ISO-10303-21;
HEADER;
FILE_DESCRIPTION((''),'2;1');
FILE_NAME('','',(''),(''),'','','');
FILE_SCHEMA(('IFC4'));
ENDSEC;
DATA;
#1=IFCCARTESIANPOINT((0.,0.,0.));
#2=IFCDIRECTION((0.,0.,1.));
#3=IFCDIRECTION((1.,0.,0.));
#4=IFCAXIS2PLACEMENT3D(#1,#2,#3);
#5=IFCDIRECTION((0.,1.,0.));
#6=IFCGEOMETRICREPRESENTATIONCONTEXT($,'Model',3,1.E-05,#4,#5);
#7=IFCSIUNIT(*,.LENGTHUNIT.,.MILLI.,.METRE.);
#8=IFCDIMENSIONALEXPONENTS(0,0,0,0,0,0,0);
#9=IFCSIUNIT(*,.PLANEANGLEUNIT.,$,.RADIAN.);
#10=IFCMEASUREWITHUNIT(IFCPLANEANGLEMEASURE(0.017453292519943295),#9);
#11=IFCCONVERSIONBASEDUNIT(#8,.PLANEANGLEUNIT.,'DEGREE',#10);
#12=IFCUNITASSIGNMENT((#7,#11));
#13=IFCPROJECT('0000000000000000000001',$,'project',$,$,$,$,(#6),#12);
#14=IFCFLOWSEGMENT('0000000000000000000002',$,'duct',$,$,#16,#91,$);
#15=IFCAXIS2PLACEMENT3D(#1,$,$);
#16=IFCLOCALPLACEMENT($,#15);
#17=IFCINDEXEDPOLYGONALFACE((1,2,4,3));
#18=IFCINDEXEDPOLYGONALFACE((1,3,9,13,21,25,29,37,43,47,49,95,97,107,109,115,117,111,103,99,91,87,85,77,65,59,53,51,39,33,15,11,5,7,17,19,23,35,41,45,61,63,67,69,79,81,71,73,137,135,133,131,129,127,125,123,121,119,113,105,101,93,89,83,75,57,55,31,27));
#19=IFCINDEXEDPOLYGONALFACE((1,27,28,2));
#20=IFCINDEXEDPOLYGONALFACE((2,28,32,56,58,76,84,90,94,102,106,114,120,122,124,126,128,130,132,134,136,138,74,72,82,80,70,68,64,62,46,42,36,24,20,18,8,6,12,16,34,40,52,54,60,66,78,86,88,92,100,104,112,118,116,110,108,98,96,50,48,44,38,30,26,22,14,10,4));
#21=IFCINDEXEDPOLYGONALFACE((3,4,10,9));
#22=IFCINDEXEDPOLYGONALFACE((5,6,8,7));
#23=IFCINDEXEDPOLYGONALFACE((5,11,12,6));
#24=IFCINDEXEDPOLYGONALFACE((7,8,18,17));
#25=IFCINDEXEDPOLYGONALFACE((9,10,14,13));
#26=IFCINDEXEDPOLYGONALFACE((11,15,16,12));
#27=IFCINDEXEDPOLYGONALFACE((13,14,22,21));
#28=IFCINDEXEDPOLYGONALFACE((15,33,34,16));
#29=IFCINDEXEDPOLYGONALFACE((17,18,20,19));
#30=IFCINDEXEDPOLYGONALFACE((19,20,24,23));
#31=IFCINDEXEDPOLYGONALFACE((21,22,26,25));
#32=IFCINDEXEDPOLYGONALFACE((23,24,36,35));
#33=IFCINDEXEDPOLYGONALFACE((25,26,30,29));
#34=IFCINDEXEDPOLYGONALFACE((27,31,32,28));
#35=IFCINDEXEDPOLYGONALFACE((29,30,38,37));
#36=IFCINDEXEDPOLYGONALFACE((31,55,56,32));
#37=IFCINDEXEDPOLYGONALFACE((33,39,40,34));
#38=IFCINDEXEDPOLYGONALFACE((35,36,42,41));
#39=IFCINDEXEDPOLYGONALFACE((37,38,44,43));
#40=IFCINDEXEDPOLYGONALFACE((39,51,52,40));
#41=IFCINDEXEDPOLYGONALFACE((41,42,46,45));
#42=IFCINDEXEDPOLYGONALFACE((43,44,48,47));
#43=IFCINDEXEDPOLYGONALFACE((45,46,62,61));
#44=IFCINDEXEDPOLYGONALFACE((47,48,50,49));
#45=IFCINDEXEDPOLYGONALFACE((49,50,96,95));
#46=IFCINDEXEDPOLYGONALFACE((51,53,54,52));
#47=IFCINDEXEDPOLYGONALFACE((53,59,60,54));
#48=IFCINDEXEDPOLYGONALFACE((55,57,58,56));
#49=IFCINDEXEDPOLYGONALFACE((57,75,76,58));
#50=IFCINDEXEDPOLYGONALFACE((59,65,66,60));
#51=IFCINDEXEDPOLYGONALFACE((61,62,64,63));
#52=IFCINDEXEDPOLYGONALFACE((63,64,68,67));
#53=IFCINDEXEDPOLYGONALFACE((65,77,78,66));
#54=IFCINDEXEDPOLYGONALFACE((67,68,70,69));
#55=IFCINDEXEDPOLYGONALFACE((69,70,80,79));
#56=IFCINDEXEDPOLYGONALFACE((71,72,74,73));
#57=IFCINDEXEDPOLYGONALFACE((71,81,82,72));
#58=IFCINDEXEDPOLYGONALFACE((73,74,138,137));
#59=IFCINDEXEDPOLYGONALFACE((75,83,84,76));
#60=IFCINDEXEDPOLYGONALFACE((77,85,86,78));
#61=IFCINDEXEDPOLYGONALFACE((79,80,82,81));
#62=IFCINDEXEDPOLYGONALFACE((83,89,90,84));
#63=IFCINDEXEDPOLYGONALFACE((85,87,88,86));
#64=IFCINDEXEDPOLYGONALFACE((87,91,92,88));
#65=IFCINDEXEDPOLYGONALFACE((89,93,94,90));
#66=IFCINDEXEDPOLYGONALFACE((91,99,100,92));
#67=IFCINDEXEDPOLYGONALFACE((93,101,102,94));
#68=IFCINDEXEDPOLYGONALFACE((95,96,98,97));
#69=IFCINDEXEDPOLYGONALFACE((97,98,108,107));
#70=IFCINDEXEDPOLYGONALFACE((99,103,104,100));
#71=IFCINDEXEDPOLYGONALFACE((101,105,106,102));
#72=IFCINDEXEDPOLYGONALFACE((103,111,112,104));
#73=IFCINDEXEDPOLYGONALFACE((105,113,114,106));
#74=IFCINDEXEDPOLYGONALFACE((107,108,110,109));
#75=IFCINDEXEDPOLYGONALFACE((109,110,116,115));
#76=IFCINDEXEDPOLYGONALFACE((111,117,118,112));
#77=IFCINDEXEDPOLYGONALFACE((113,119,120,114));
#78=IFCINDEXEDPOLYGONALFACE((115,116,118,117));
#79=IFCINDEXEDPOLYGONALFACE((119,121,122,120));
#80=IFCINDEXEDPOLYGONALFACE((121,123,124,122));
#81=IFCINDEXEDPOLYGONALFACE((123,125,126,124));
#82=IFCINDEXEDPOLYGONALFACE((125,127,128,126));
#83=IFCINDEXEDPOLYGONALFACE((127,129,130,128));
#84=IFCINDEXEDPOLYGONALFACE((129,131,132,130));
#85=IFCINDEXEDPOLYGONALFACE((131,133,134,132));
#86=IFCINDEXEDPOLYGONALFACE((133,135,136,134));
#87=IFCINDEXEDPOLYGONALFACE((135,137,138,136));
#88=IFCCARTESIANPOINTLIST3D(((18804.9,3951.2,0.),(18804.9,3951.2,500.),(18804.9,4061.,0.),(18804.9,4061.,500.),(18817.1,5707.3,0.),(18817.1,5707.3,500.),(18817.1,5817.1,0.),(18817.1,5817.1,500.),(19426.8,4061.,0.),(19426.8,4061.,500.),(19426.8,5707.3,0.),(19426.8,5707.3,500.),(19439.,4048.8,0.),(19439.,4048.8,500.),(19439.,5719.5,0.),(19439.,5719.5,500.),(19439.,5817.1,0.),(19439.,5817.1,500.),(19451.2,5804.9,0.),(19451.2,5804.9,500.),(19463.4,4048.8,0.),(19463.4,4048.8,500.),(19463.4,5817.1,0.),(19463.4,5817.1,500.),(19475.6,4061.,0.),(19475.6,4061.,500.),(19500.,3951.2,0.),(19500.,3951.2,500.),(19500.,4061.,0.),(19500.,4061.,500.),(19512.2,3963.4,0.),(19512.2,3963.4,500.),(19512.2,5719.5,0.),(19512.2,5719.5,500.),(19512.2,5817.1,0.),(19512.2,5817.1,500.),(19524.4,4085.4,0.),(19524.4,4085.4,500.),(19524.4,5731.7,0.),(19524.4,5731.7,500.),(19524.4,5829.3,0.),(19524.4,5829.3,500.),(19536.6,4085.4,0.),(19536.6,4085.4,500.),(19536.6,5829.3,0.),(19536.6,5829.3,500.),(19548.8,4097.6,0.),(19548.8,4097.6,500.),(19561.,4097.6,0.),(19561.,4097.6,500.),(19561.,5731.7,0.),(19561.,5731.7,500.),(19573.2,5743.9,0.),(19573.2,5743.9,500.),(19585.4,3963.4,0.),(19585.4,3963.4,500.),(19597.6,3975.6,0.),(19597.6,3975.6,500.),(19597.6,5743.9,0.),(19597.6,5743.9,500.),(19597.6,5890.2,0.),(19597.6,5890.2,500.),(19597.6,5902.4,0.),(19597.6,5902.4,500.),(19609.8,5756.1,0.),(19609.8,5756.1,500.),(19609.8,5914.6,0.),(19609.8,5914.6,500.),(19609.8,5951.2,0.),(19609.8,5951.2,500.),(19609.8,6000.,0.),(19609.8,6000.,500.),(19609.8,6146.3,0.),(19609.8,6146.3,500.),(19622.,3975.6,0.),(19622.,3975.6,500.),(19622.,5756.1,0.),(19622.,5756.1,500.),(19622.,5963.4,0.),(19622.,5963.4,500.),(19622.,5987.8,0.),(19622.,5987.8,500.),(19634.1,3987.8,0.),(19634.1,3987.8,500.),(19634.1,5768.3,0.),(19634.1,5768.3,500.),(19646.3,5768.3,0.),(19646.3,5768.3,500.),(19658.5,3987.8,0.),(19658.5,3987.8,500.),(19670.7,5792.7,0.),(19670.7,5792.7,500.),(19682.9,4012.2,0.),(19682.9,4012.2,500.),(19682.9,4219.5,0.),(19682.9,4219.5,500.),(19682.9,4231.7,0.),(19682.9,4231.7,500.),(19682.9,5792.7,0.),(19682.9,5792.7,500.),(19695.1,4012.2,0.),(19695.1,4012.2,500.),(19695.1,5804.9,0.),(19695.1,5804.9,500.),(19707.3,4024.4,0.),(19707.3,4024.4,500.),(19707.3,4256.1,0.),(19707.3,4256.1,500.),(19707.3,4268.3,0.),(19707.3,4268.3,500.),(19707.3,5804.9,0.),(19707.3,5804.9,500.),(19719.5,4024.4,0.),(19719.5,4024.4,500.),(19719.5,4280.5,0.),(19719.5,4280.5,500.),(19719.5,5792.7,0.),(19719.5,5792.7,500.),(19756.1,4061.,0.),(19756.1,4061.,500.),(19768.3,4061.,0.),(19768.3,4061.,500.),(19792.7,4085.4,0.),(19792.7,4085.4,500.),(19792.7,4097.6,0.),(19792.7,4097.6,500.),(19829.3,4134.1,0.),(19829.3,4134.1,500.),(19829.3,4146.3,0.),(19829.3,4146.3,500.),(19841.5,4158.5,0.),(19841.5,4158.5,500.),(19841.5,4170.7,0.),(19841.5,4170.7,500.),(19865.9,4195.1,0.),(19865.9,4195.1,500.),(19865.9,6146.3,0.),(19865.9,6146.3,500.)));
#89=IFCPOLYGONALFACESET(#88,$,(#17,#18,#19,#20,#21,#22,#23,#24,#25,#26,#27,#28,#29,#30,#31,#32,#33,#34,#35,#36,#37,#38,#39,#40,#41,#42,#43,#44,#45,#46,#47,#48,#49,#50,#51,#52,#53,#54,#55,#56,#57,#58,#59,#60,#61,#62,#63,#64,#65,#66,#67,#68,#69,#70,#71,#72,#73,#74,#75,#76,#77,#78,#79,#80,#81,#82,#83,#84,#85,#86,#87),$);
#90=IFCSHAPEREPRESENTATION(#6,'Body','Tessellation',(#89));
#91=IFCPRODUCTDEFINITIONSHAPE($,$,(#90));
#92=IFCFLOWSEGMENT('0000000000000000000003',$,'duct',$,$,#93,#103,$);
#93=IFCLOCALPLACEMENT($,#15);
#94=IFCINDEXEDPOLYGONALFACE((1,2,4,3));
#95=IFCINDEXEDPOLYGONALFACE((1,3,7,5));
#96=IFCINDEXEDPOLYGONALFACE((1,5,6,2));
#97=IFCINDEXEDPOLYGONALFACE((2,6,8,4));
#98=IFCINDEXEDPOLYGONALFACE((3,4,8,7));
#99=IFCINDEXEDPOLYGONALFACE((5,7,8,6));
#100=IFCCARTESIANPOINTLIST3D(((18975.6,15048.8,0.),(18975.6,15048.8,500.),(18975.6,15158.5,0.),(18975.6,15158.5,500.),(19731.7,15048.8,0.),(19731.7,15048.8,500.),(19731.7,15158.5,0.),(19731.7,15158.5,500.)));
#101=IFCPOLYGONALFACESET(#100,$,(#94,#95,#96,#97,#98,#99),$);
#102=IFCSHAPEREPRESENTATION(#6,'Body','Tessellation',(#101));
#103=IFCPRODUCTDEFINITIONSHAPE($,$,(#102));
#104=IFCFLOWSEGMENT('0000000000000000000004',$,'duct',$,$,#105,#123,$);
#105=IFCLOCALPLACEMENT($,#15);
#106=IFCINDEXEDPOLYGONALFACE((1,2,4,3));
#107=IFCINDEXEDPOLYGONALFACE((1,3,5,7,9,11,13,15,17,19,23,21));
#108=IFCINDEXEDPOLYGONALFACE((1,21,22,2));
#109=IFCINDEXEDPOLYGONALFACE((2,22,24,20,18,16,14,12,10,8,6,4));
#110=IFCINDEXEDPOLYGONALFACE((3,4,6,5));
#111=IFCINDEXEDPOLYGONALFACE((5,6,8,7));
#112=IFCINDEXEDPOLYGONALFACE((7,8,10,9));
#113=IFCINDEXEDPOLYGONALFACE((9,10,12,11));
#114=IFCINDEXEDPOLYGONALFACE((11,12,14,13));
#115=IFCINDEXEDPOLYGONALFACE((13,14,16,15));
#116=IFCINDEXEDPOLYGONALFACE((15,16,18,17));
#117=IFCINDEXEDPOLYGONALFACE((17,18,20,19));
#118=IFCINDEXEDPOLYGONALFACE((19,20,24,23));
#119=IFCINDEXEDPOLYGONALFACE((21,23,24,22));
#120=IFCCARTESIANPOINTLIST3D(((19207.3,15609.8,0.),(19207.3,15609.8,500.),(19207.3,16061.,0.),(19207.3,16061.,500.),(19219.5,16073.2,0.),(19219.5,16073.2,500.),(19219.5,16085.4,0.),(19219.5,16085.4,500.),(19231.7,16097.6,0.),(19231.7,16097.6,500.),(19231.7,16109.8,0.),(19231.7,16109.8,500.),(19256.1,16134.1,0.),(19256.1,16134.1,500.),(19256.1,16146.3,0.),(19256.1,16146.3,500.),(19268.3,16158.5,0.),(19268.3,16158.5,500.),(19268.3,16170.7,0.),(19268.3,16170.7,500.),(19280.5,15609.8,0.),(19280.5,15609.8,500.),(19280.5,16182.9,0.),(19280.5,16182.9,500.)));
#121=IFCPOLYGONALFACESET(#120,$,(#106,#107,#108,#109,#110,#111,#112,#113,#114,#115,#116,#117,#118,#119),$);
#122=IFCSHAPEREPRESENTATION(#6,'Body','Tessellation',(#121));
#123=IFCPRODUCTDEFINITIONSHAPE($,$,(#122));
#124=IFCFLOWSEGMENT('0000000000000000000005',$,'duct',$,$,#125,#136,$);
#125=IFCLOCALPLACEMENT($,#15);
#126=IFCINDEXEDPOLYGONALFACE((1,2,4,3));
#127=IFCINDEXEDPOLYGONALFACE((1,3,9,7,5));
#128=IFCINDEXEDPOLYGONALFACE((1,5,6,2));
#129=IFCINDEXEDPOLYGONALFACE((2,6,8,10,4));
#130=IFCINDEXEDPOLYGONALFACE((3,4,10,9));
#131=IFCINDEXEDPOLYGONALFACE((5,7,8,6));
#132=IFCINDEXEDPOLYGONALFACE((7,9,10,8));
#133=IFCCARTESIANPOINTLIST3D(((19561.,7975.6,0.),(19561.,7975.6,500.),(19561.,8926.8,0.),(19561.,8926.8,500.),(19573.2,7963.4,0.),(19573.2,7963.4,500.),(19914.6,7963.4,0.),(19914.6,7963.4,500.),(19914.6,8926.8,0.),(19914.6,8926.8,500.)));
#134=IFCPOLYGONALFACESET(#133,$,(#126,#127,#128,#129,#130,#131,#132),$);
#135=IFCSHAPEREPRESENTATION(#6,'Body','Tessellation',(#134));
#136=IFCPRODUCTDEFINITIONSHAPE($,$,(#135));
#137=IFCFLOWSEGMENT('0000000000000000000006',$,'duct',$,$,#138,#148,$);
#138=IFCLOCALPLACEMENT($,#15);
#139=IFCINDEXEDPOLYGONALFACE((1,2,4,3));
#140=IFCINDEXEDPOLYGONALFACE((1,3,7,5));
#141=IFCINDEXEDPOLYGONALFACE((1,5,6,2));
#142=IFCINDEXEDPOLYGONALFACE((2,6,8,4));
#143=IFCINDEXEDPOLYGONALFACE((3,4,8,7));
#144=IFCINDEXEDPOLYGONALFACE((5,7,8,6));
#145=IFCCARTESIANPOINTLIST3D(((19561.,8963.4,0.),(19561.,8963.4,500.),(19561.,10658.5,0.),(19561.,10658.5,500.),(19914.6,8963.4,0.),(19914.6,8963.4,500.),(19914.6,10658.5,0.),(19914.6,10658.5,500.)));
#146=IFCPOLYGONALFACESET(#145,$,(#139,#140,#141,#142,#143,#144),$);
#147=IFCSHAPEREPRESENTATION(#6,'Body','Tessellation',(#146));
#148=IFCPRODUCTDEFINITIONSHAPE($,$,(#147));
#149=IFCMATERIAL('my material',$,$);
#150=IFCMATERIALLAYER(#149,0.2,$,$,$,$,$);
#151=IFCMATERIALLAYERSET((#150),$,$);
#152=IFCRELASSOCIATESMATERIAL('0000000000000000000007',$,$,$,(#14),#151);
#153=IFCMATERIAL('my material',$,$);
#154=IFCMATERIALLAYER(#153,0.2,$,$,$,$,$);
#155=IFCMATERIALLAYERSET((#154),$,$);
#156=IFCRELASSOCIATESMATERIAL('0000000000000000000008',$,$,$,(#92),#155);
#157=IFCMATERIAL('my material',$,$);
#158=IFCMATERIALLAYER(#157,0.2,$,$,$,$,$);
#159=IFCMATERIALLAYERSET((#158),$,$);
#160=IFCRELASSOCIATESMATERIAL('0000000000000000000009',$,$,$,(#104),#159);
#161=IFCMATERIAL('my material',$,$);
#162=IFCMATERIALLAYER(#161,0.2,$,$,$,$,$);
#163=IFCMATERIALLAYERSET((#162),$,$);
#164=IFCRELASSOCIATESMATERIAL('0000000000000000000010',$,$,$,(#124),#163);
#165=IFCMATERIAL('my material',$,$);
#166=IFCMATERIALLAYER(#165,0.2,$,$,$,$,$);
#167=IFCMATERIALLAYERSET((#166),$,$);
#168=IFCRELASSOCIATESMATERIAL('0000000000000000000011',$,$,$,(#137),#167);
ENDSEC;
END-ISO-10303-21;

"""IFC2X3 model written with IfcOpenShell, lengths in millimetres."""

from ifc_helpers import new_model, entity, si_unit, converted_unit, direction, origin_with_axes, place, context, project, polyline, outline, extrude, material, layer, layer_set, layer_usage, element, save


model = new_model("IFC2X3")

# Units and contexts
model_context = context("Model", 3, precision=1e-05, world=origin_with_axes(), true_north=direction((0.0, 1.0, 0.0)))
ifc_project = project(units=[si_unit("LENGTHUNIT", "METRE", prefix="MILLI"), converted_unit("PLANEANGLEUNIT", "DEGREE", entity("IfcPlaneAngleMeasure", 0.017453292519943295), si_unit("PLANEANGLEUNIT", "RADIAN"), dimensions=[0, 0, 0, 0, 0, 0, 0])], contexts=[model_context])

# Flow segments
ifc_material_1 = material(Name="my material")
ifc_layer_1 = layer(ifc_material_1, 0.2)
ifc_layer_set_1 = layer_set([ifc_layer_1])
ifc_layer_usage_1 = layer_usage(ifc_layer_set_1, "AXIS2", "POSITIVE", -0.1)
flow_segment_1_placement = place(None, origin_with_axes())
element("IfcFlowSegment", 1, at=flow_segment_1_placement, material=ifc_layer_usage_1, Name="duct", context=model_context, shape_type="SweptSolid", body=[
    extrude(outline(polyline([(18804.9, 3951.2), (19500.0, 3951.2), (19512.2, 3963.4), (19585.4, 3963.4), (19597.6, 3975.6), (19622.0, 3975.6), (19634.1, 3987.8), (19658.5, 3987.8), (19682.9, 4012.2), (19695.1, 4012.2), (19707.3, 4024.4), (19719.5, 4024.4), (19756.1, 4061.0), (19768.3, 4061.0), (19792.7, 4085.4), (19792.7, 4097.6), (19829.3, 4134.1), (19829.3, 4146.3), (19841.5, 4158.5), (19841.5, 4170.7), (19865.9, 4195.1), (19865.9, 6146.3), (19609.8, 6146.3), (19609.8, 6000.0), (19622.0, 5987.8), (19622.0, 5963.4), (19609.8, 5951.2), (19609.8, 5914.6), (19597.6, 5902.4), (19597.6, 5890.2), (19536.6, 5829.3), (19524.4, 5829.3), (19512.2, 5817.1), (19463.4, 5817.1), (19451.2, 5804.9), (19439.0, 5817.1), (18817.1, 5817.1), (18817.1, 5707.3), (19426.8, 5707.3), (19439.0, 5719.5), (19512.2, 5719.5), (19524.4, 5731.7), (19561.0, 5731.7), (19573.2, 5743.9), (19597.6, 5743.9), (19609.8, 5756.1), (19622.0, 5756.1), (19634.1, 5768.3), (19646.3, 5768.3), (19670.7, 5792.7), (19682.9, 5792.7), (19695.1, 5804.9), (19707.3, 5804.9), (19719.5, 5792.7), (19719.5, 4280.5), (19707.3, 4268.3), (19707.3, 4256.1), (19682.9, 4231.7), (19682.9, 4219.5), (19561.0, 4097.6), (19548.8, 4097.6), (19536.6, 4085.4), (19524.4, 4085.4), (19500.0, 4061.0), (19475.6, 4061.0), (19463.4, 4048.8), (19439.0, 4048.8), (19426.8, 4061.0), (18804.9, 4061.0), (18804.9, 3951.2)])), origin_with_axes(), (0.0, 0.0, 1.0), 500.0),
])
ifc_material_2 = material(Name="my material")
ifc_layer_2 = layer(ifc_material_2, 0.2)
ifc_layer_set_2 = layer_set([ifc_layer_2])
ifc_layer_usage_2 = layer_usage(ifc_layer_set_2, "AXIS2", "POSITIVE", -0.1)
flow_segment_2_placement = place(None, origin_with_axes())
element("IfcFlowSegment", 2, at=flow_segment_2_placement, material=ifc_layer_usage_2, Name="duct", context=model_context, shape_type="SweptSolid", body=[
    extrude(outline(polyline([(18975.6, 15048.8), (19731.7, 15048.8), (19731.7, 15158.5), (18975.6, 15158.5), (18975.6, 15048.8)])), origin_with_axes(), (0.0, 0.0, 1.0), 500.0),
])
ifc_material_3 = material(Name="my material")
ifc_layer_3 = layer(ifc_material_3, 0.2)
ifc_layer_set_3 = layer_set([ifc_layer_3])
ifc_layer_usage_3 = layer_usage(ifc_layer_set_3, "AXIS2", "POSITIVE", -0.1)
flow_segment_3_placement = place(None, origin_with_axes())
element("IfcFlowSegment", 3, at=flow_segment_3_placement, material=ifc_layer_usage_3, Name="duct", context=model_context, shape_type="SweptSolid", body=[
    extrude(outline(polyline([(19207.3, 15609.8), (19280.5, 15609.8), (19280.5, 16195.1), (19280.5, 16182.9), (19268.3, 16170.7), (19268.3, 16158.5), (19256.1, 16146.3), (19256.1, 16134.1), (19231.7, 16109.8), (19231.7, 16097.6), (19219.5, 16085.4), (19219.5, 16073.2), (19207.3, 16061.0), (19207.3, 15609.8)])), origin_with_axes(), (0.0, 0.0, 1.0), 500.0),
])
ifc_material_4 = material(Name="my material")
ifc_layer_4 = layer(ifc_material_4, 0.2)
ifc_layer_set_4 = layer_set([ifc_layer_4])
ifc_layer_usage_4 = layer_usage(ifc_layer_set_4, "AXIS2", "POSITIVE", -0.1)
flow_segment_4_placement = place(None, origin_with_axes())
element("IfcFlowSegment", 4, at=flow_segment_4_placement, material=ifc_layer_usage_4, Name="duct", context=model_context, shape_type="SweptSolid", body=[
    extrude(outline(polyline([(19561.0, 7975.6), (19573.2, 7963.4), (19914.6, 7963.4), (19914.6, 8926.8), (19561.0, 8926.8), (19561.0, 7975.6)])), origin_with_axes(), (0.0, 0.0, 1.0), 500.0),
])
ifc_material_5 = material(Name="my material")
ifc_layer_5 = layer(ifc_material_5, 0.2)
ifc_layer_set_5 = layer_set([ifc_layer_5])
ifc_layer_usage_5 = layer_usage(ifc_layer_set_5, "AXIS2", "POSITIVE", -0.1)
flow_segment_5_placement = place(None, origin_with_axes())
element("IfcFlowSegment", 5, at=flow_segment_5_placement, material=ifc_layer_usage_5, Name="duct", context=model_context, shape_type="SweptSolid", body=[
    extrude(outline(polyline([(19561.0, 8963.4), (19914.6, 8963.4), (19914.6, 10658.5), (19561.0, 10658.5), (19561.0, 8963.4)])), origin_with_axes(), (0.0, 0.0, 1.0), 500.0),
])

save(model, "model.ifc")
